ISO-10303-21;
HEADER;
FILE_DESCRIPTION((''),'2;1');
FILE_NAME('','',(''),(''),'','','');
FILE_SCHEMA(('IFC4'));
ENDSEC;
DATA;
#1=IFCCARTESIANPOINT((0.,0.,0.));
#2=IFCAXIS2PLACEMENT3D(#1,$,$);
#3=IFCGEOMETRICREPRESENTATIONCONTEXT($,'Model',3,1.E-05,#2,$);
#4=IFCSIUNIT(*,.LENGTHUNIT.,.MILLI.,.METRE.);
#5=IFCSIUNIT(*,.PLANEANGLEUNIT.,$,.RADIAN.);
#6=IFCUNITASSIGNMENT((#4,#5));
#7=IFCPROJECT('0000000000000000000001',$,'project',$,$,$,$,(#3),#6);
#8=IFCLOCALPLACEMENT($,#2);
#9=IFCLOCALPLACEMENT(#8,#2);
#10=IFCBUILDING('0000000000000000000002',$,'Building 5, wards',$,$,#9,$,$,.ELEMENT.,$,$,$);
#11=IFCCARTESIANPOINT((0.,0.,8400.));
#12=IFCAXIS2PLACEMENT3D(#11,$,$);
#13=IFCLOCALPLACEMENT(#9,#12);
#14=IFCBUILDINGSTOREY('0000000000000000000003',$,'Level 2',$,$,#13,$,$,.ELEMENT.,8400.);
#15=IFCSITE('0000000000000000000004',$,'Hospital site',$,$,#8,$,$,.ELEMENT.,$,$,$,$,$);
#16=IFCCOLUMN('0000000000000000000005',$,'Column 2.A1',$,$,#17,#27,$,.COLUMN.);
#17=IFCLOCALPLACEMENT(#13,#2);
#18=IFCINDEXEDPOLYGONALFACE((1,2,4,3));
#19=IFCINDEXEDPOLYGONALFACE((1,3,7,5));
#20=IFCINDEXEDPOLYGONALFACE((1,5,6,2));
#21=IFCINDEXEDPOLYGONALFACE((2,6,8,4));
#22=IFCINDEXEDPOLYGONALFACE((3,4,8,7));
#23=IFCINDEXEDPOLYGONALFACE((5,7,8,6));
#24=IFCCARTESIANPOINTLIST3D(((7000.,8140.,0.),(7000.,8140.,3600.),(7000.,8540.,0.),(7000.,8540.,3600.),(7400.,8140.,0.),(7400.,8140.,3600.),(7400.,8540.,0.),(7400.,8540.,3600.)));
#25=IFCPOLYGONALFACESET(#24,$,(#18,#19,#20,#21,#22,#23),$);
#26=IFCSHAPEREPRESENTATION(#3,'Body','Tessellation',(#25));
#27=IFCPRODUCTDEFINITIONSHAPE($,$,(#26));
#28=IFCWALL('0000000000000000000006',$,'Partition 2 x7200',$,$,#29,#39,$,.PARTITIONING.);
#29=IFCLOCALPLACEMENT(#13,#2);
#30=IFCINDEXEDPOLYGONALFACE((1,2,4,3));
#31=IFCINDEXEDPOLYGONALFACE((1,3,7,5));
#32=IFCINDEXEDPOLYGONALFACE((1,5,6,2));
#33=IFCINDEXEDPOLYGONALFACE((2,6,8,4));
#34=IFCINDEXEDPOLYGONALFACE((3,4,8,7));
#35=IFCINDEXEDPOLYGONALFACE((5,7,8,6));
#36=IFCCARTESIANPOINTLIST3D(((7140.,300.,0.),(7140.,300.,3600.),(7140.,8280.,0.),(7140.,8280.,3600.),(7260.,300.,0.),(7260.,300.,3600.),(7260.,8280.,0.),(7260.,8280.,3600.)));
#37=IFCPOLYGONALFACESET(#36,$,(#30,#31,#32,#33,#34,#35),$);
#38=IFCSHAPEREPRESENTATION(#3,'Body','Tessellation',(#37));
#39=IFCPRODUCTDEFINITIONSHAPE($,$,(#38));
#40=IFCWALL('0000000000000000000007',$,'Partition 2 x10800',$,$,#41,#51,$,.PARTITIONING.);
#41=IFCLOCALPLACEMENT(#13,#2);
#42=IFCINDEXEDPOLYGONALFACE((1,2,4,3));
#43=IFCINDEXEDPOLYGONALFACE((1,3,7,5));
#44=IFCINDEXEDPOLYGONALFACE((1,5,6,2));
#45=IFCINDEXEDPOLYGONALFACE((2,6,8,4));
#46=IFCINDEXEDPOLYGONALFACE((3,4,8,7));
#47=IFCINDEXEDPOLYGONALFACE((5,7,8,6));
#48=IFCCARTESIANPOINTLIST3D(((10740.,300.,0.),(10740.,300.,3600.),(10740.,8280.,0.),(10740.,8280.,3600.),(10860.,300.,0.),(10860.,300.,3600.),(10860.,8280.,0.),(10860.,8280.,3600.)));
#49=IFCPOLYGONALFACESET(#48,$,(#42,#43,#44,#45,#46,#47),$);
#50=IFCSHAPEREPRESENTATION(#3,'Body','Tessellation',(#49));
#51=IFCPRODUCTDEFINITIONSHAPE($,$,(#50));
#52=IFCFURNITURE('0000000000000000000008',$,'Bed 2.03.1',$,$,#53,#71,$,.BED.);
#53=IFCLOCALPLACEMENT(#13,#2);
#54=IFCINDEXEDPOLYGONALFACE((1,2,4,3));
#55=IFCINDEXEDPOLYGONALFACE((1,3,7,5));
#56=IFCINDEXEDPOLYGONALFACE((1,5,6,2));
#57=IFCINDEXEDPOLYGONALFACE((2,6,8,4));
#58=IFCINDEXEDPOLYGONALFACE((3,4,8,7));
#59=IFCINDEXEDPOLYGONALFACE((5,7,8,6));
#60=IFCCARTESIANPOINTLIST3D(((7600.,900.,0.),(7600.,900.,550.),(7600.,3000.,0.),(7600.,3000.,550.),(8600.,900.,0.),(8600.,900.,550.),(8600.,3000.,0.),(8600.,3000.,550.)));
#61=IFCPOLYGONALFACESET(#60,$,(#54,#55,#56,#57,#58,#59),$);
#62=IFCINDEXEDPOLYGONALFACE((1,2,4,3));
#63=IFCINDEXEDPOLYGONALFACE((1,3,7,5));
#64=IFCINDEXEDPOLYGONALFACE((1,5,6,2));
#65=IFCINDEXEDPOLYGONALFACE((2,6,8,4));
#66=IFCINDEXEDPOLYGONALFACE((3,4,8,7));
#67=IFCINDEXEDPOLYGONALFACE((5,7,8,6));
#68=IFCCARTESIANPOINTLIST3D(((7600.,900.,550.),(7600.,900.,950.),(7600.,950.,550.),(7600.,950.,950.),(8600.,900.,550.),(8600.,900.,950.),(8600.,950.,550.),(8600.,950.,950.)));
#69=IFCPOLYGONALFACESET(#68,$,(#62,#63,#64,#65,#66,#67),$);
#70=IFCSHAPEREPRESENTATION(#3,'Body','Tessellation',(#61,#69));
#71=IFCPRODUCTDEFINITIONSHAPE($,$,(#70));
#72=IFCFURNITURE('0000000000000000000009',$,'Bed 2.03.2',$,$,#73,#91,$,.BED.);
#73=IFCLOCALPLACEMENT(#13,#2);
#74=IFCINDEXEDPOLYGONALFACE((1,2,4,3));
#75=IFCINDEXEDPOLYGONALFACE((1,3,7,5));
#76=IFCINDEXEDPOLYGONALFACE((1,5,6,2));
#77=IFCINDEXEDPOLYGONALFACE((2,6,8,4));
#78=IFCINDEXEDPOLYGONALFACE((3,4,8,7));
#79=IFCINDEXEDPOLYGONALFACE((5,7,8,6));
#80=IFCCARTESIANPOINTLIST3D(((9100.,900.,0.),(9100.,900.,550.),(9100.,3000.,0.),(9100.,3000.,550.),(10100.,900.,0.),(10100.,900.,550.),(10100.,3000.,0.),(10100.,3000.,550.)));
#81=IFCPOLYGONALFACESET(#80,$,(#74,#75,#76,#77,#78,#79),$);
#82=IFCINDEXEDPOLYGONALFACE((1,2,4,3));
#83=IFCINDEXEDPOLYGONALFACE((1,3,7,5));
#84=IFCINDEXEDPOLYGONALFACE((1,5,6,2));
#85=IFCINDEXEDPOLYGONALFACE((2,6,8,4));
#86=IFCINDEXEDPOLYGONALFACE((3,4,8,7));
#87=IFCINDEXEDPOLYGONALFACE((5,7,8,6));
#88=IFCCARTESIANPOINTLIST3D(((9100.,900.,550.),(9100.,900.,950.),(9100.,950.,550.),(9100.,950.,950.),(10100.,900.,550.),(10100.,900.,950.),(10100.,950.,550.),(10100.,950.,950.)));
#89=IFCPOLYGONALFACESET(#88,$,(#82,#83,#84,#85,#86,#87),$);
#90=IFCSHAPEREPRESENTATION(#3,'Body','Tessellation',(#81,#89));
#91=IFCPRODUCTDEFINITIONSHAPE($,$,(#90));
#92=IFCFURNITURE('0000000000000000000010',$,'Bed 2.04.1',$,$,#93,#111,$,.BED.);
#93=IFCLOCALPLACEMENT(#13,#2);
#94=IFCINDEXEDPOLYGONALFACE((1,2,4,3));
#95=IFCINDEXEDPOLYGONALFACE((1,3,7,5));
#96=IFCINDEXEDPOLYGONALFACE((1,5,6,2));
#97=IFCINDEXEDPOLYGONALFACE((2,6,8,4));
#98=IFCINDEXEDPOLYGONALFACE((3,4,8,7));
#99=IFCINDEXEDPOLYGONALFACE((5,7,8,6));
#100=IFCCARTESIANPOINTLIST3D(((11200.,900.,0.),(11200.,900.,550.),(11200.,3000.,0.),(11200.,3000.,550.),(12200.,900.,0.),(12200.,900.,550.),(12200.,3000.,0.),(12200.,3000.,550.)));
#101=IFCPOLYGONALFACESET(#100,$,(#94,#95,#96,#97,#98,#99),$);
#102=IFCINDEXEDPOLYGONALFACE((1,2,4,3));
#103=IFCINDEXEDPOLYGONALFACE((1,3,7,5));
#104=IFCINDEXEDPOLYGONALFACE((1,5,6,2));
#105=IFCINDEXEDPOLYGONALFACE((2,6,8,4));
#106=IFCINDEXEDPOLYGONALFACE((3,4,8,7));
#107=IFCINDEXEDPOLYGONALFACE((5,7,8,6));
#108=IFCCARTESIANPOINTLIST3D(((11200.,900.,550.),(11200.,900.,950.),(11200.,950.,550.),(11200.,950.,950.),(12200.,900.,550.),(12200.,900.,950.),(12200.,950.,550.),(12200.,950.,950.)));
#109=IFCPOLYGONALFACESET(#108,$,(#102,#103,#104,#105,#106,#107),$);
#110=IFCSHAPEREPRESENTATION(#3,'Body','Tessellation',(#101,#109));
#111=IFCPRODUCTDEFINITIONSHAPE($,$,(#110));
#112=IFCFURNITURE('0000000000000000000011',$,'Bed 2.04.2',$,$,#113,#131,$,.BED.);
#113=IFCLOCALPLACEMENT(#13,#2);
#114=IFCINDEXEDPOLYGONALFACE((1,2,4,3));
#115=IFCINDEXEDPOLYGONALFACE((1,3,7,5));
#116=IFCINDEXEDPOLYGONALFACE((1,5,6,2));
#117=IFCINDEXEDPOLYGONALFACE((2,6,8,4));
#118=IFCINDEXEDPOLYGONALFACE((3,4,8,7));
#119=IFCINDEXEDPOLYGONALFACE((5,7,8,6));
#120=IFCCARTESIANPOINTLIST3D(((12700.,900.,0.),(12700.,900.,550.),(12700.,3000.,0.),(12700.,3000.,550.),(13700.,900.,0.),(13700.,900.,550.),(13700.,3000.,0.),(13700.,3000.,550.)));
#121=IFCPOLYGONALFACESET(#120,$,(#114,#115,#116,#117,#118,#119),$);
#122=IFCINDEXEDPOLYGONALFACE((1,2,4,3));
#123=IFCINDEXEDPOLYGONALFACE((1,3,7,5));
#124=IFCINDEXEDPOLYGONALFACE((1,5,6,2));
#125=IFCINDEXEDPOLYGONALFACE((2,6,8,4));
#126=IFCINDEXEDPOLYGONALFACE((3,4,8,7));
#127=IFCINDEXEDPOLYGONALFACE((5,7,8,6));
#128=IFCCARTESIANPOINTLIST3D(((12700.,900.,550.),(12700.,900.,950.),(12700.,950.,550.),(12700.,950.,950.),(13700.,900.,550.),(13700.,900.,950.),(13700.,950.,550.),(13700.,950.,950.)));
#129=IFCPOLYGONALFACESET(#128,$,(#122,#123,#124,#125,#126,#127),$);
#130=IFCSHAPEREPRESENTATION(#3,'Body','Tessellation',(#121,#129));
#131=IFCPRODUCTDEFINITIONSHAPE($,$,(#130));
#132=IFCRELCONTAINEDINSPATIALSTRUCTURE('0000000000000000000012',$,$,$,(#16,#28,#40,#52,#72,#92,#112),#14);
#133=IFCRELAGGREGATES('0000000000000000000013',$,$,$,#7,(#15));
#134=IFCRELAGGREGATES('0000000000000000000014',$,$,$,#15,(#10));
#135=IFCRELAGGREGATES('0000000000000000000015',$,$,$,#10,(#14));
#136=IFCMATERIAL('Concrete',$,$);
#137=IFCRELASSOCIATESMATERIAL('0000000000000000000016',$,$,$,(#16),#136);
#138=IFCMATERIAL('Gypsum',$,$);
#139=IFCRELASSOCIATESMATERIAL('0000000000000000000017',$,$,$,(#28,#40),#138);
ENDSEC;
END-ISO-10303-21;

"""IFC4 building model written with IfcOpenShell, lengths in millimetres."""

from ifc_helpers import new_model, si_unit, frame, frame_2d, origin, origin_2d, place, context, project, spatial, rectangle, extrude, material, element, save


model = new_model("IFC4")

# Units and contexts
model_context = context("Model", 3, precision=1e-05, world=origin())
ifc_project = project(units=[si_unit("LENGTHUNIT", "METRE", prefix="MILLI"), si_unit("PLANEANGLEUNIT", "RADIAN")], contexts=[model_context])

# Site, building, storey
site_placement = place(None, origin())
site = spatial("IfcSite", under=ifc_project, at=site_placement, Name="Hospital site", CompositionType="ELEMENT")
building_placement = place(site_placement, origin())
building = spatial("IfcBuilding", under=site, at=building_placement, Name="Building 5, wards", CompositionType="ELEMENT")
storey_placement = place(building_placement, frame((0.0, 0.0, 8400.0)))
storey = spatial("IfcBuildingStorey", under=building, at=storey_placement, Name="Level 2", CompositionType="ELEMENT", Elevation=8400.0)

# Column
ifc_material_1 = material(Name="Concrete")
column_placement = place(storey_placement, frame((7200.0, 8340.0, 0.0)))
element("IfcColumn", 1, at=column_placement, inside=storey, material=ifc_material_1, Name="Column 2.A1", PredefinedType="COLUMN", context=model_context, shape_type="SweptSolid", body=[
    extrude(rectangle(XDim=400.0, YDim=400.0, at=origin_2d()), origin(), (0.0, 0.0, 1.0), 3600.0),
])

# Walls
ifc_material_2 = material(Name="Gypsum")
for number, where, x_axis, name in (
    (2, (7260.0, 300.0, 0.0), (0.0, 1.0, 0.0), "Partition 2 x7200"),
    (3, (10860.0, 300.0, 0.0), (0.0, 1.0, 0.0), "Partition 2 x10800"),
):
    element("IfcWall", number, at=place(storey_placement, frame(where, x_axis=x_axis)), inside=storey, material=ifc_material_2, Name=name, PredefinedType="PARTITIONING", context=model_context, shape_type="SweptSolid", body=[
        extrude(rectangle(XDim=7980.0, YDim=120.0, at=frame_2d((3990.0, 60.0))), origin(), (0.0, 0.0, 1.0), 3600.0),
    ])

# Furniture
for number, where, name in (
    (4, (7600.0, 900.0, 0.0), "Bed 2.03.1"),
    (5, (9100.0, 900.0, 0.0), "Bed 2.03.2"),
    (6, (11200.0, 900.0, 0.0), "Bed 2.04.1"),
    (7, (12700.0, 900.0, 0.0), "Bed 2.04.2"),
):
    element("IfcFurniture", number, at=place(storey_placement, frame(where)), inside=storey, Name=name, PredefinedType="BED", context=model_context, shape_type="SweptSolid", body=[
        extrude(rectangle(XDim=1000.0, YDim=2100.0, at=frame_2d((500.0, 1050.0))), origin(), (0.0, 0.0, 1.0), 550.0),
        extrude(rectangle(XDim=1000.0, YDim=50.0, at=frame_2d((500.0, 25.0))), frame((0.0, 0.0, 550.0)), (0.0, 0.0, 1.0), 400.0),
    ])

save(model, "model.ifc")
